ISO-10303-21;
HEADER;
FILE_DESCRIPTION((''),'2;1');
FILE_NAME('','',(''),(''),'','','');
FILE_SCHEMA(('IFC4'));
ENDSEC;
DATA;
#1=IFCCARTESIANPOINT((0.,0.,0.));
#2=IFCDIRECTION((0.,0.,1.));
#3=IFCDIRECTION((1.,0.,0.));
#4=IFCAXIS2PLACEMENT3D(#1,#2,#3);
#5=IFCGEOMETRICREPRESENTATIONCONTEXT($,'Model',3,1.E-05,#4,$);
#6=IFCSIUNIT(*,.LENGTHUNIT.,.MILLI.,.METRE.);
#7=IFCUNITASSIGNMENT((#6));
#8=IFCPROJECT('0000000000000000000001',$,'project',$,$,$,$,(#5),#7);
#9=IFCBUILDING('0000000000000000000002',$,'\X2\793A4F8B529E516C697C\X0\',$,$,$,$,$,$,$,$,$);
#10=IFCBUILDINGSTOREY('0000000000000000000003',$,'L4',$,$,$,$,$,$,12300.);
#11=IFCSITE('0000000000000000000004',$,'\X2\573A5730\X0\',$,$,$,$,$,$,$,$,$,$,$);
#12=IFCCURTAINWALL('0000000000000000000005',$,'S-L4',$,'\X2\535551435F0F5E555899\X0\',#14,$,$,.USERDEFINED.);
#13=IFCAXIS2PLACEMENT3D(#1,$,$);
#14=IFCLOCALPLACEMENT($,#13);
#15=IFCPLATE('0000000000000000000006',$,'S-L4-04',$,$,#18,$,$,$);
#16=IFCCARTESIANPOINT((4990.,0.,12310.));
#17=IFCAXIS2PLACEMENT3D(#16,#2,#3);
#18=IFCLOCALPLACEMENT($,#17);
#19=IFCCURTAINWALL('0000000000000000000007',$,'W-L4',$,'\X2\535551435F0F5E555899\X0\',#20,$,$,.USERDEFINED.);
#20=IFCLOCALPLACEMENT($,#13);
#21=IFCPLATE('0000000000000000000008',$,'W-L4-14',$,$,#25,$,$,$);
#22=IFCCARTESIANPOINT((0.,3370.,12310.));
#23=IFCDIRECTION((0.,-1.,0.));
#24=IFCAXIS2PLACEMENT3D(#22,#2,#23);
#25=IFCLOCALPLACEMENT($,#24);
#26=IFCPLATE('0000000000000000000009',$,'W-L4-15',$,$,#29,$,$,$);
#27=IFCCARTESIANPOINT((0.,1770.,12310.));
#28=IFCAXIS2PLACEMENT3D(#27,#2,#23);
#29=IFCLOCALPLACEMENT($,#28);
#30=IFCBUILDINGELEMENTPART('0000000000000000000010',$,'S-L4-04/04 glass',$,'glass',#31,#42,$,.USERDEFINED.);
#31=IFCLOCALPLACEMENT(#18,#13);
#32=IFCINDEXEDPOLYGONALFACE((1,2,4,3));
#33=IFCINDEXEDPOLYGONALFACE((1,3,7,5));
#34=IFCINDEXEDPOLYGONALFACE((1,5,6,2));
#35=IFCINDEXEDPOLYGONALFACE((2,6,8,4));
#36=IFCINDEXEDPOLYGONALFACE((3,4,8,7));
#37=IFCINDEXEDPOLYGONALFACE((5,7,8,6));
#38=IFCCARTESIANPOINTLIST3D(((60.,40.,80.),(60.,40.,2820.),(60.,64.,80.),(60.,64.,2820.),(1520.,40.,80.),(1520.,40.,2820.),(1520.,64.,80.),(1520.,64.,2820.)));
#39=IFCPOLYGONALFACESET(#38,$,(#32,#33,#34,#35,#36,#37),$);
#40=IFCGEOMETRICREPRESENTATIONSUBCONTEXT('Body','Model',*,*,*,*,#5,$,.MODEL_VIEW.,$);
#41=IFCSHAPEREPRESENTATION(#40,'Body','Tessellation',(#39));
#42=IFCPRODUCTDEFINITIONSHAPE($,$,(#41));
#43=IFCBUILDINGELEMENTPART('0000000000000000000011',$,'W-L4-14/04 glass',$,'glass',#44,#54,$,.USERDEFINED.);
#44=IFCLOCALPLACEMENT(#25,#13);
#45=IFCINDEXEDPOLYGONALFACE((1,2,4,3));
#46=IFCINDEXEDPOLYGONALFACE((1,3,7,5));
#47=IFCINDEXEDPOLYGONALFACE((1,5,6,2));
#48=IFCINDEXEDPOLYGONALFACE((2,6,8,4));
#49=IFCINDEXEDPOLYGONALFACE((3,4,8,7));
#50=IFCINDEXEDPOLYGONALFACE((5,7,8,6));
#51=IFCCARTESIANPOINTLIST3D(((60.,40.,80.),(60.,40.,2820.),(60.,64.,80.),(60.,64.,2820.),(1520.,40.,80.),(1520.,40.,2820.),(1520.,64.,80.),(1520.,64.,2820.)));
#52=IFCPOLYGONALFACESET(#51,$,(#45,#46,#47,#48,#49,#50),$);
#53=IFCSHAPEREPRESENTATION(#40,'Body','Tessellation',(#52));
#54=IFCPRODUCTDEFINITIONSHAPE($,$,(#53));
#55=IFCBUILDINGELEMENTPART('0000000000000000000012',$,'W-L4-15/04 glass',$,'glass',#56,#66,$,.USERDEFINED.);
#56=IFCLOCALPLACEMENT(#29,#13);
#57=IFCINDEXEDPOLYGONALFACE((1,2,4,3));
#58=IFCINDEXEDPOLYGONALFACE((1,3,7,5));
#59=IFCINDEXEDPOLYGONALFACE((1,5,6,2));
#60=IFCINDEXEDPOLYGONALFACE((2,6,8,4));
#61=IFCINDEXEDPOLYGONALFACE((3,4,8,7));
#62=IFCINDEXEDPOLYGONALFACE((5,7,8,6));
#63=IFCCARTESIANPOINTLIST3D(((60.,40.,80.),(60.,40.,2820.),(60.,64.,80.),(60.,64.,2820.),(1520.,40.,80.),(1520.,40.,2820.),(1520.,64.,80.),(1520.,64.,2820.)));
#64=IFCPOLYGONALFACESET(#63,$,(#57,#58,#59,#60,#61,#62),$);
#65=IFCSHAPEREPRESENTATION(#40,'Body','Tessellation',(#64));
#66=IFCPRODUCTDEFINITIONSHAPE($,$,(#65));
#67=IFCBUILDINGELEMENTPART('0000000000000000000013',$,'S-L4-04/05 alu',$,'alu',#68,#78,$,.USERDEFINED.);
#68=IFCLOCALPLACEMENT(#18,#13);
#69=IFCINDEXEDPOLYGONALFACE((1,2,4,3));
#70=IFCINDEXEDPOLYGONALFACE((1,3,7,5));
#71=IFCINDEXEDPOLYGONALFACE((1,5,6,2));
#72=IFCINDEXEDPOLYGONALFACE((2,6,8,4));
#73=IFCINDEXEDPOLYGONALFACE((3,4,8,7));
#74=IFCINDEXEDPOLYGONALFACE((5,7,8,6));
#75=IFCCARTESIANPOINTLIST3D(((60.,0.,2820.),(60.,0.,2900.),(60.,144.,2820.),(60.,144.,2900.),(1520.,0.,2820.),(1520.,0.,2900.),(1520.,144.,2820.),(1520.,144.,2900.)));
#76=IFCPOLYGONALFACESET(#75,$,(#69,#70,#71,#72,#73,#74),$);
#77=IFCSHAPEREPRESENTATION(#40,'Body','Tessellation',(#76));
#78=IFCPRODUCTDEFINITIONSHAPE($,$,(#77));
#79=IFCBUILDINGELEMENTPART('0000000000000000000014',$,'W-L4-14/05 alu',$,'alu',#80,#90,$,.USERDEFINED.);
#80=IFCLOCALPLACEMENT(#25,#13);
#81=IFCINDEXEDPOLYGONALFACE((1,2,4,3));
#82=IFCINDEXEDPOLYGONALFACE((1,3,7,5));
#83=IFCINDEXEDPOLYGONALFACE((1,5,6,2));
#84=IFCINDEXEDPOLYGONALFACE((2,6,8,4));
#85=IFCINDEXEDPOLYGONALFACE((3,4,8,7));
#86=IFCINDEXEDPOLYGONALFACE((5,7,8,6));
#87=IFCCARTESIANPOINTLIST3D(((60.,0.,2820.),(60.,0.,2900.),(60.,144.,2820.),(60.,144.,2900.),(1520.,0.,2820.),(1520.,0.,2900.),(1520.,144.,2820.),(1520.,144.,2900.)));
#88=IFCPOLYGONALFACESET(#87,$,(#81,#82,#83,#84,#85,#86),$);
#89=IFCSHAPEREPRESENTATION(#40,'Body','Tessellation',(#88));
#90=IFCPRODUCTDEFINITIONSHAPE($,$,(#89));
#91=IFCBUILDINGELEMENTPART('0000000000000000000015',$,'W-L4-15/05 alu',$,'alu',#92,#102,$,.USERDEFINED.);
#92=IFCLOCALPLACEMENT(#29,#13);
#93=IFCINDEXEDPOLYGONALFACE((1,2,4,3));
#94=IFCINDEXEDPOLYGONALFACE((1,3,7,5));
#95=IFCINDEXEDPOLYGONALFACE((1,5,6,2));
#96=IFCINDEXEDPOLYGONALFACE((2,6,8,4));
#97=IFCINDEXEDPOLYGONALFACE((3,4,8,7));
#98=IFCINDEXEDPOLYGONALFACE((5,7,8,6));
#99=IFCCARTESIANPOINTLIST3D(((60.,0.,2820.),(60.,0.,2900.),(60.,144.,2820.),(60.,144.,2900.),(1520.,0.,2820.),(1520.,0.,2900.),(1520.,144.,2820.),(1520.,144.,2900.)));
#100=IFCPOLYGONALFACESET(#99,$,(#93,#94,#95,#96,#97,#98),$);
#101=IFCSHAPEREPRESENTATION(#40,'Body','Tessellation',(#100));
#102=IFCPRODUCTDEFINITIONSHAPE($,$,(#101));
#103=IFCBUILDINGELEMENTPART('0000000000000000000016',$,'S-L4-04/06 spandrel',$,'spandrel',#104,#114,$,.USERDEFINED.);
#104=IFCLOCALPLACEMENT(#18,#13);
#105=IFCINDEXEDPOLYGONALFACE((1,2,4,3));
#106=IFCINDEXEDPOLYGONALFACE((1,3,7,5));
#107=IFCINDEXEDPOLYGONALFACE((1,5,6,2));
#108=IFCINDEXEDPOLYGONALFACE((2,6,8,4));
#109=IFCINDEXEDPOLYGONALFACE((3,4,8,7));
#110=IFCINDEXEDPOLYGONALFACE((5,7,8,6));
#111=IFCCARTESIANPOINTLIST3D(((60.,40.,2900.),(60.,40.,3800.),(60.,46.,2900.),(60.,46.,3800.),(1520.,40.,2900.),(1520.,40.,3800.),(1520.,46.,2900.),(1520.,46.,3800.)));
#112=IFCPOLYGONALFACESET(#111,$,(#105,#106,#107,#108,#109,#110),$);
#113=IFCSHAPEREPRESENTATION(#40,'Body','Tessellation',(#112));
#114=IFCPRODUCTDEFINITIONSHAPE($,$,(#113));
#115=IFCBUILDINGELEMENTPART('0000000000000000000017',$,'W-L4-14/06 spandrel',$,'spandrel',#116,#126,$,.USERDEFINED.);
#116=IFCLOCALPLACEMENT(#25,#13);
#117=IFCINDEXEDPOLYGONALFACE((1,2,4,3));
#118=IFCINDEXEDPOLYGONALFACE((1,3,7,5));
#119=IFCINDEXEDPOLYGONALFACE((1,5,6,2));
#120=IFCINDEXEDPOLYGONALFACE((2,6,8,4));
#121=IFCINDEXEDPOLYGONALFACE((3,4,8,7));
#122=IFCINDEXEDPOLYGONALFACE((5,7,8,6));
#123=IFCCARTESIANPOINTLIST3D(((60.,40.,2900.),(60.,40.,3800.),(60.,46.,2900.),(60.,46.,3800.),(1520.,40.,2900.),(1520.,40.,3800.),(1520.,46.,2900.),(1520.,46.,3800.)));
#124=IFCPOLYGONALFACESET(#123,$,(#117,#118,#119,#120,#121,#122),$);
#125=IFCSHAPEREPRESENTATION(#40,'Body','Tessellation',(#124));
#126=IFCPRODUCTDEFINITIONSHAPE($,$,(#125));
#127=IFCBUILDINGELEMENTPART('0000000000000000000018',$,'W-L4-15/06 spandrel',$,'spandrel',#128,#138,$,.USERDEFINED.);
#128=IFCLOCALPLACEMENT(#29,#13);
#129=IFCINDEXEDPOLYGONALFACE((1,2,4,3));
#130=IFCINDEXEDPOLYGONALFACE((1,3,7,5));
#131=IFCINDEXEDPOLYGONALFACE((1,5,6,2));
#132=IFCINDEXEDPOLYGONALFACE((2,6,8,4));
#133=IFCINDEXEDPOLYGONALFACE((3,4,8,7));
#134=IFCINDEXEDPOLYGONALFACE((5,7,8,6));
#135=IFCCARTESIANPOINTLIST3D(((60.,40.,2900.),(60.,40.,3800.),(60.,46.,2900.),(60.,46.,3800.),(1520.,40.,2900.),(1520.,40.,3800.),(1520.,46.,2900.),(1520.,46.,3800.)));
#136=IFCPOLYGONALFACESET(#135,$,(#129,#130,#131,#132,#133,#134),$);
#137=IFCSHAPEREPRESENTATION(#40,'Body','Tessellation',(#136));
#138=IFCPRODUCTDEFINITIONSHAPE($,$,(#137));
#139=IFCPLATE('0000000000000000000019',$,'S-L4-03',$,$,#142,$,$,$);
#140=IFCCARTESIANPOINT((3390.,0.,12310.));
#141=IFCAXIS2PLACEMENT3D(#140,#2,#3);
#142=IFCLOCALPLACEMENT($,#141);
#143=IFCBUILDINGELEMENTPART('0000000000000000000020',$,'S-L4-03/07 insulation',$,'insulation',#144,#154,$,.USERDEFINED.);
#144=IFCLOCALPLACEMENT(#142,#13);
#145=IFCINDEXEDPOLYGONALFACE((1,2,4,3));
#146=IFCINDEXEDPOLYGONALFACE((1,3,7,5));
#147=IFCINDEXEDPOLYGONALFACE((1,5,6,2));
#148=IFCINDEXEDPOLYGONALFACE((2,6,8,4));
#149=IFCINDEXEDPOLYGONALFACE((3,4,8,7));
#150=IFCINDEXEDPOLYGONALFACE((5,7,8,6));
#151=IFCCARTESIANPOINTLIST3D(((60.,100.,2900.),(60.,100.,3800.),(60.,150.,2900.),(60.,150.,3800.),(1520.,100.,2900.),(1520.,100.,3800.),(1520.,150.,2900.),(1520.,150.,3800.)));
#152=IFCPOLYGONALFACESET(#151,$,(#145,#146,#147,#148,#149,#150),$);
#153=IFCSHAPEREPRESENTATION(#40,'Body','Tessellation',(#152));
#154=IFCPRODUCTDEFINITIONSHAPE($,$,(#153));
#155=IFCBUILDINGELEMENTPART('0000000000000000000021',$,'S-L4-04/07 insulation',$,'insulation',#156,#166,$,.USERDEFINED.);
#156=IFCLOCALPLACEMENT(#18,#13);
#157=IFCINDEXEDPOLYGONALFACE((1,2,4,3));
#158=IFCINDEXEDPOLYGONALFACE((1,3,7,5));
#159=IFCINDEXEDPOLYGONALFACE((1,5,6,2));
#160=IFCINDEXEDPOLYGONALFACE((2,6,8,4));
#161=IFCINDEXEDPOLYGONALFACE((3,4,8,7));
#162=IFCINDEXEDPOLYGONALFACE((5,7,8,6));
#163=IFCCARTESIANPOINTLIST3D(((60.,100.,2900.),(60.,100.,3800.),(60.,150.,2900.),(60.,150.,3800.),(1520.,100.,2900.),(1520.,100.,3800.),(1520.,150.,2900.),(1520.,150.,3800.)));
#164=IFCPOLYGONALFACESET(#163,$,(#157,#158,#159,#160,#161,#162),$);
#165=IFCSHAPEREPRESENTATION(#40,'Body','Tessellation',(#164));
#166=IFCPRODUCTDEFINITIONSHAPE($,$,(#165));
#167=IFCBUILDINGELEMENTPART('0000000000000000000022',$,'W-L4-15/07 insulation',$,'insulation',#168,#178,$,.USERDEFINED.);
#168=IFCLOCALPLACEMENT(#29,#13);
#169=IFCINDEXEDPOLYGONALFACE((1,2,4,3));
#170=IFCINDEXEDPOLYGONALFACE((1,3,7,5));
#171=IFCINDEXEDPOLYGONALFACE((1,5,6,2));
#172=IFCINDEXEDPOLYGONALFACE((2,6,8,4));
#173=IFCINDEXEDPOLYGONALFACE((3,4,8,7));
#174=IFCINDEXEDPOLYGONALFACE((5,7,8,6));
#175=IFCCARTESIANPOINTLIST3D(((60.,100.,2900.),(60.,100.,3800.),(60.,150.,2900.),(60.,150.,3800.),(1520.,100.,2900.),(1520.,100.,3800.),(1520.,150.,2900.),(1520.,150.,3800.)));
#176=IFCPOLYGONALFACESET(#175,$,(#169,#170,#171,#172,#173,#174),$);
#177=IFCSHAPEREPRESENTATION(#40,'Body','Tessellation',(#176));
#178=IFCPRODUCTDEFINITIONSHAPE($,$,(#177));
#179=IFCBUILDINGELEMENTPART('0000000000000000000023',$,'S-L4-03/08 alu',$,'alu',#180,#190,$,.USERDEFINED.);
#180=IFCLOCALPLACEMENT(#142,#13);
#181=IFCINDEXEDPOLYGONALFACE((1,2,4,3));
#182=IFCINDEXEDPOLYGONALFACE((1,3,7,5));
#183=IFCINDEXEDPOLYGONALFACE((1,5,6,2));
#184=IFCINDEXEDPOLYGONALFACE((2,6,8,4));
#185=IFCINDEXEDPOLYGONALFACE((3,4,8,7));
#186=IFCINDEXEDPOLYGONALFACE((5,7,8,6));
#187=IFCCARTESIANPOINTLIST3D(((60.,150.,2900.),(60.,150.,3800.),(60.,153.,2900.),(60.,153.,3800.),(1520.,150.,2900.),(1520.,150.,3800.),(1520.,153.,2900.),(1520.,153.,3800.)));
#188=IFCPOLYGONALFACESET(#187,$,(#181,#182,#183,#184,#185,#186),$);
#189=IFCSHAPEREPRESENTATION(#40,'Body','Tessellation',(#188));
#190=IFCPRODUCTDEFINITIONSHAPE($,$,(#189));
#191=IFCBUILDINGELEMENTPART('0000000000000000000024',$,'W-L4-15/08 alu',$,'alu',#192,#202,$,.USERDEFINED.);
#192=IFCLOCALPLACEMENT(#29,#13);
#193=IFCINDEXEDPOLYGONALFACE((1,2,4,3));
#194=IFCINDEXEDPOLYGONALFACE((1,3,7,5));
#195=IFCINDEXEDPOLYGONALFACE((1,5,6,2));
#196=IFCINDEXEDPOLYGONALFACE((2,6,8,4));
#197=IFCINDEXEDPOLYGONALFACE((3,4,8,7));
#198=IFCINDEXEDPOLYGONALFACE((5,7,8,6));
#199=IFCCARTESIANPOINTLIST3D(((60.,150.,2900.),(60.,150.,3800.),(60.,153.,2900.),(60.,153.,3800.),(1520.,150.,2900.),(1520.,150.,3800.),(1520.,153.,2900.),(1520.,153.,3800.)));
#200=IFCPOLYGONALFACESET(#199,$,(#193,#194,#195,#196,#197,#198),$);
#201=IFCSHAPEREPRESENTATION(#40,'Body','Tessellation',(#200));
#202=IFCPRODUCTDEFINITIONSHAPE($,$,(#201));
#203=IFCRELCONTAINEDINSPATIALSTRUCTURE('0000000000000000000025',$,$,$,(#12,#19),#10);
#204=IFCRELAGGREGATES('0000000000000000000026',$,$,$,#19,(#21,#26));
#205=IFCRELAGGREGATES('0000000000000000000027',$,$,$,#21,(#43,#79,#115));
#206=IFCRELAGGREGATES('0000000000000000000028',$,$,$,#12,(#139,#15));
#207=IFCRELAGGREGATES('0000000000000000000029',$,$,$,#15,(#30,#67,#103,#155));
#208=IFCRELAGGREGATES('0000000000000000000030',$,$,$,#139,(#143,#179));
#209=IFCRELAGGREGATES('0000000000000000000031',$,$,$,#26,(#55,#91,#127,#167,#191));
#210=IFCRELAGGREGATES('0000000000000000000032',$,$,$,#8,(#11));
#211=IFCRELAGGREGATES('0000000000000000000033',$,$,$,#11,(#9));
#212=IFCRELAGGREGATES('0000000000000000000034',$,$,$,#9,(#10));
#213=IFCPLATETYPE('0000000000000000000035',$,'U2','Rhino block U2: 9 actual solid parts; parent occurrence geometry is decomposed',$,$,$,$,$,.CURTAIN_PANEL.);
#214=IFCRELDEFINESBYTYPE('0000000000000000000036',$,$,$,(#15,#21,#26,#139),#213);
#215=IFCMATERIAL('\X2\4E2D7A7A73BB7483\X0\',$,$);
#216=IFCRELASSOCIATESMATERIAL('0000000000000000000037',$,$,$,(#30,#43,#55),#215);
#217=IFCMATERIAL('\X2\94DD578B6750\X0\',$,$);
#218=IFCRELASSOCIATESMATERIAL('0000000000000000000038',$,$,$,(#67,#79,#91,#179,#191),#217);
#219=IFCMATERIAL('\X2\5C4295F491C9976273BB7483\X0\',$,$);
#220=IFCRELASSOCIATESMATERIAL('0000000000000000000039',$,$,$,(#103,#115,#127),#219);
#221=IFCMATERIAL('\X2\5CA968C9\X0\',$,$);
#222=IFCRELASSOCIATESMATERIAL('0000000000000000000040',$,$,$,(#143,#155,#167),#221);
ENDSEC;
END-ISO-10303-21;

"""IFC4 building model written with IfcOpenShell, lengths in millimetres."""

from ifc_helpers import new_model, si_unit, frame, frame_2d, origin, origin_with_axes, place, context, subcontext, project, spatial, rectangle, extrude, source, transform, mapped, material, type_object, element, aggregate, save


model = new_model("IFC4")

# Units and contexts
model_context = context("Model", 3, precision=1e-05, world=origin_with_axes())
body_context = subcontext(model_context, "Body", "Model", "MODEL_VIEW")
ifc_project = project(units=[si_unit("LENGTHUNIT", "METRE", prefix="MILLI")], contexts=[model_context])

# Site, building, storey
site = spatial("IfcSite", under=ifc_project, Name="场地")
building = spatial("IfcBuilding", under=site, Name="示例办公楼")
storey = spatial("IfcBuildingStorey", under=building, Name="L4", Elevation=12300.0)

# Curtain wall, plate
curtain_wall_1 = element("IfcCurtainWall", 1, inside=storey, Name="S-L4", ObjectType="单元式幕墙", PredefinedType="USERDEFINED")
plate_type = type_object("IfcPlateType", Name="U2", Description="Rhino block U2: 9 actual solid parts; parent occurrence geometry is decomposed", PredefinedType="CURTAIN_PANEL")
plate_1_placement = place(None, frame((4990.0, 0.0, 12310.0), z_axis=(0.0, 0.0, 1.0), x_axis=(1.0, 0.0, 0.0)))
plate_1 = element("IfcPlate", 2, at=plate_1_placement, type_object=plate_type, Name="S-L4-04")
ifc_material_1 = material(Name="铝型材")

# Curtain wall, plates
curtain_wall_2 = element("IfcCurtainWall", 3, inside=storey, Name="W-L4", ObjectType="单元式幕墙", PredefinedType="USERDEFINED")
plate_2_placement = place(None, frame((0.0, 3370.0, 12310.0), z_axis=(0.0, 0.0, 1.0), x_axis=(0.0, -1.0, 0.0)))
plate_2 = element("IfcPlate", 4, at=plate_2_placement, type_object=plate_type, Name="W-L4-14")
plate_3_placement = place(None, frame((0.0, 1770.0, 12310.0), z_axis=(0.0, 0.0, 1.0), x_axis=(0.0, -1.0, 0.0)))
plate_3 = element("IfcPlate", 5, at=plate_3_placement, type_object=plate_type, Name="W-L4-15")
aggregate(curtain_wall_2, [plate_2, plate_3])

# Building element parts
ifc_material_2 = material(Name="中空玻璃")
shared_shape_1 = source(origin(), body_context, "Body", "SweptSolid", [
    extrude(rectangle(XDim=1460.0, YDim=24.0, at=frame_2d((790.0, 52.0))), frame((0.0, 0.0, 80.0)), (0.0, 0.0, 1.0), 2740.0),
])
building_element_part_1_placement = place(plate_1_placement, origin())
building_element_part_1 = element("IfcBuildingElementPart", 6, at=building_element_part_1_placement, material=ifc_material_2, Name="S-L4-04/04 glass", ObjectType="glass", PredefinedType="USERDEFINED", context=body_context, shape_type="MappedRepresentation", body=[
    mapped(shared_shape_1, transform((0.0, 0.0, 0.0))),
])
building_element_part_2_placement = place(plate_2_placement, origin())
building_element_part_2 = element("IfcBuildingElementPart", 7, at=building_element_part_2_placement, material=ifc_material_2, Name="W-L4-14/04 glass", ObjectType="glass", PredefinedType="USERDEFINED", context=body_context, shape_type="MappedRepresentation", body=[
    mapped(shared_shape_1, transform((0.0, 0.0, 0.0))),
])
building_element_part_3_placement = place(plate_3_placement, origin())
building_element_part_3 = element("IfcBuildingElementPart", 8, at=building_element_part_3_placement, material=ifc_material_2, Name="W-L4-15/04 glass", ObjectType="glass", PredefinedType="USERDEFINED", context=body_context, shape_type="MappedRepresentation", body=[
    mapped(shared_shape_1, transform((0.0, 0.0, 0.0))),
])
shared_shape_2 = source(origin(), body_context, "Body", "SweptSolid", [
    extrude(rectangle(XDim=1460.0, YDim=144.0, at=frame_2d((790.0, 72.0))), frame((0.0, 0.0, 2820.0)), (0.0, 0.0, 1.0), 80.0),
])
building_element_part_4_placement = place(plate_1_placement, origin())
building_element_part_4 = element("IfcBuildingElementPart", 9, at=building_element_part_4_placement, material=ifc_material_1, Name="S-L4-04/05 alu", ObjectType="alu", PredefinedType="USERDEFINED", context=body_context, shape_type="MappedRepresentation", body=[
    mapped(shared_shape_2, transform((0.0, 0.0, 0.0))),
])
building_element_part_5_placement = place(plate_2_placement, origin())
building_element_part_5 = element("IfcBuildingElementPart", 10, at=building_element_part_5_placement, material=ifc_material_1, Name="W-L4-14/05 alu", ObjectType="alu", PredefinedType="USERDEFINED", context=body_context, shape_type="MappedRepresentation", body=[
    mapped(shared_shape_2, transform((0.0, 0.0, 0.0))),
])
building_element_part_6_placement = place(plate_3_placement, origin())
building_element_part_6 = element("IfcBuildingElementPart", 11, at=building_element_part_6_placement, material=ifc_material_1, Name="W-L4-15/05 alu", ObjectType="alu", PredefinedType="USERDEFINED", context=body_context, shape_type="MappedRepresentation", body=[
    mapped(shared_shape_2, transform((0.0, 0.0, 0.0))),
])
ifc_material_3 = material(Name="层间釉面玻璃")
shared_shape_3 = source(origin(), body_context, "Body", "SweptSolid", [
    extrude(rectangle(XDim=1460.0, YDim=6.0, at=frame_2d((790.0, 43.0))), frame((0.0, 0.0, 2900.0)), (0.0, 0.0, 1.0), 900.0),
])
building_element_part_7_placement = place(plate_1_placement, origin())
building_element_part_7 = element("IfcBuildingElementPart", 12, at=building_element_part_7_placement, material=ifc_material_3, Name="S-L4-04/06 spandrel", ObjectType="spandrel", PredefinedType="USERDEFINED", context=body_context, shape_type="MappedRepresentation", body=[
    mapped(shared_shape_3, transform((0.0, 0.0, 0.0))),
])
building_element_part_8_placement = place(plate_2_placement, origin())
building_element_part_8 = element("IfcBuildingElementPart", 13, at=building_element_part_8_placement, material=ifc_material_3, Name="W-L4-14/06 spandrel", ObjectType="spandrel", PredefinedType="USERDEFINED", context=body_context, shape_type="MappedRepresentation", body=[
    mapped(shared_shape_3, transform((0.0, 0.0, 0.0))),
])
aggregate(plate_2, [building_element_part_2, building_element_part_5, building_element_part_8])
building_element_part_9_placement = place(plate_3_placement, origin())
building_element_part_9 = element("IfcBuildingElementPart", 14, at=building_element_part_9_placement, material=ifc_material_3, Name="W-L4-15/06 spandrel", ObjectType="spandrel", PredefinedType="USERDEFINED", context=body_context, shape_type="MappedRepresentation", body=[
    mapped(shared_shape_3, transform((0.0, 0.0, 0.0))),
])

# Plate
plate_4_placement = place(None, frame((3390.0, 0.0, 12310.0), z_axis=(0.0, 0.0, 1.0), x_axis=(1.0, 0.0, 0.0)))
plate_4 = element("IfcPlate", 15, at=plate_4_placement, type_object=plate_type, Name="S-L4-03")
aggregate(curtain_wall_1, [plate_4, plate_1])

# Building element parts
ifc_material_4 = material(Name="岩棉")
shared_shape_4 = source(origin(), body_context, "Body", "SweptSolid", [
    extrude(rectangle(XDim=1460.0, YDim=50.0, at=frame_2d((790.0, 125.0))), frame((0.0, 0.0, 2900.0)), (0.0, 0.0, 1.0), 900.0),
])
building_element_part_10_placement = place(plate_4_placement, origin())
building_element_part_10 = element("IfcBuildingElementPart", 16, at=building_element_part_10_placement, material=ifc_material_4, Name="S-L4-03/07 insulation", ObjectType="insulation", PredefinedType="USERDEFINED", context=body_context, shape_type="MappedRepresentation", body=[
    mapped(shared_shape_4, transform((0.0, 0.0, 0.0))),
])
building_element_part_11_placement = place(plate_1_placement, origin())
building_element_part_11 = element("IfcBuildingElementPart", 17, at=building_element_part_11_placement, material=ifc_material_4, Name="S-L4-04/07 insulation", ObjectType="insulation", PredefinedType="USERDEFINED", context=body_context, shape_type="MappedRepresentation", body=[
    mapped(shared_shape_4, transform((0.0, 0.0, 0.0))),
])
aggregate(plate_1, [building_element_part_1, building_element_part_4, building_element_part_7, building_element_part_11])
building_element_part_12_placement = place(plate_3_placement, origin())
building_element_part_12 = element("IfcBuildingElementPart", 18, at=building_element_part_12_placement, material=ifc_material_4, Name="W-L4-15/07 insulation", ObjectType="insulation", PredefinedType="USERDEFINED", context=body_context, shape_type="MappedRepresentation", body=[
    mapped(shared_shape_4, transform((0.0, 0.0, 0.0))),
])
shared_shape_5 = source(origin(), body_context, "Body", "SweptSolid", [
    extrude(rectangle(XDim=1460.0, YDim=3.0, at=frame_2d((790.0, 151.5))), frame((0.0, 0.0, 2900.0)), (0.0, 0.0, 1.0), 900.0),
])
building_element_part_13_placement = place(plate_4_placement, origin())
building_element_part_13 = element("IfcBuildingElementPart", 19, at=building_element_part_13_placement, material=ifc_material_1, Name="S-L4-03/08 alu", ObjectType="alu", PredefinedType="USERDEFINED", context=body_context, shape_type="MappedRepresentation", body=[
    mapped(shared_shape_5, transform((0.0, 0.0, 0.0))),
])
building_element_part_14_placement = place(plate_3_placement, origin())
building_element_part_14 = element("IfcBuildingElementPart", 20, at=building_element_part_14_placement, material=ifc_material_1, Name="W-L4-15/08 alu", ObjectType="alu", PredefinedType="USERDEFINED", context=body_context, shape_type="MappedRepresentation", body=[
    mapped(shared_shape_5, transform((0.0, 0.0, 0.0))),
])
aggregate(plate_4, [building_element_part_10, building_element_part_13])
aggregate(plate_3, [building_element_part_3, building_element_part_6, building_element_part_9, building_element_part_12, building_element_part_14])

save(model, "model.ifc")
